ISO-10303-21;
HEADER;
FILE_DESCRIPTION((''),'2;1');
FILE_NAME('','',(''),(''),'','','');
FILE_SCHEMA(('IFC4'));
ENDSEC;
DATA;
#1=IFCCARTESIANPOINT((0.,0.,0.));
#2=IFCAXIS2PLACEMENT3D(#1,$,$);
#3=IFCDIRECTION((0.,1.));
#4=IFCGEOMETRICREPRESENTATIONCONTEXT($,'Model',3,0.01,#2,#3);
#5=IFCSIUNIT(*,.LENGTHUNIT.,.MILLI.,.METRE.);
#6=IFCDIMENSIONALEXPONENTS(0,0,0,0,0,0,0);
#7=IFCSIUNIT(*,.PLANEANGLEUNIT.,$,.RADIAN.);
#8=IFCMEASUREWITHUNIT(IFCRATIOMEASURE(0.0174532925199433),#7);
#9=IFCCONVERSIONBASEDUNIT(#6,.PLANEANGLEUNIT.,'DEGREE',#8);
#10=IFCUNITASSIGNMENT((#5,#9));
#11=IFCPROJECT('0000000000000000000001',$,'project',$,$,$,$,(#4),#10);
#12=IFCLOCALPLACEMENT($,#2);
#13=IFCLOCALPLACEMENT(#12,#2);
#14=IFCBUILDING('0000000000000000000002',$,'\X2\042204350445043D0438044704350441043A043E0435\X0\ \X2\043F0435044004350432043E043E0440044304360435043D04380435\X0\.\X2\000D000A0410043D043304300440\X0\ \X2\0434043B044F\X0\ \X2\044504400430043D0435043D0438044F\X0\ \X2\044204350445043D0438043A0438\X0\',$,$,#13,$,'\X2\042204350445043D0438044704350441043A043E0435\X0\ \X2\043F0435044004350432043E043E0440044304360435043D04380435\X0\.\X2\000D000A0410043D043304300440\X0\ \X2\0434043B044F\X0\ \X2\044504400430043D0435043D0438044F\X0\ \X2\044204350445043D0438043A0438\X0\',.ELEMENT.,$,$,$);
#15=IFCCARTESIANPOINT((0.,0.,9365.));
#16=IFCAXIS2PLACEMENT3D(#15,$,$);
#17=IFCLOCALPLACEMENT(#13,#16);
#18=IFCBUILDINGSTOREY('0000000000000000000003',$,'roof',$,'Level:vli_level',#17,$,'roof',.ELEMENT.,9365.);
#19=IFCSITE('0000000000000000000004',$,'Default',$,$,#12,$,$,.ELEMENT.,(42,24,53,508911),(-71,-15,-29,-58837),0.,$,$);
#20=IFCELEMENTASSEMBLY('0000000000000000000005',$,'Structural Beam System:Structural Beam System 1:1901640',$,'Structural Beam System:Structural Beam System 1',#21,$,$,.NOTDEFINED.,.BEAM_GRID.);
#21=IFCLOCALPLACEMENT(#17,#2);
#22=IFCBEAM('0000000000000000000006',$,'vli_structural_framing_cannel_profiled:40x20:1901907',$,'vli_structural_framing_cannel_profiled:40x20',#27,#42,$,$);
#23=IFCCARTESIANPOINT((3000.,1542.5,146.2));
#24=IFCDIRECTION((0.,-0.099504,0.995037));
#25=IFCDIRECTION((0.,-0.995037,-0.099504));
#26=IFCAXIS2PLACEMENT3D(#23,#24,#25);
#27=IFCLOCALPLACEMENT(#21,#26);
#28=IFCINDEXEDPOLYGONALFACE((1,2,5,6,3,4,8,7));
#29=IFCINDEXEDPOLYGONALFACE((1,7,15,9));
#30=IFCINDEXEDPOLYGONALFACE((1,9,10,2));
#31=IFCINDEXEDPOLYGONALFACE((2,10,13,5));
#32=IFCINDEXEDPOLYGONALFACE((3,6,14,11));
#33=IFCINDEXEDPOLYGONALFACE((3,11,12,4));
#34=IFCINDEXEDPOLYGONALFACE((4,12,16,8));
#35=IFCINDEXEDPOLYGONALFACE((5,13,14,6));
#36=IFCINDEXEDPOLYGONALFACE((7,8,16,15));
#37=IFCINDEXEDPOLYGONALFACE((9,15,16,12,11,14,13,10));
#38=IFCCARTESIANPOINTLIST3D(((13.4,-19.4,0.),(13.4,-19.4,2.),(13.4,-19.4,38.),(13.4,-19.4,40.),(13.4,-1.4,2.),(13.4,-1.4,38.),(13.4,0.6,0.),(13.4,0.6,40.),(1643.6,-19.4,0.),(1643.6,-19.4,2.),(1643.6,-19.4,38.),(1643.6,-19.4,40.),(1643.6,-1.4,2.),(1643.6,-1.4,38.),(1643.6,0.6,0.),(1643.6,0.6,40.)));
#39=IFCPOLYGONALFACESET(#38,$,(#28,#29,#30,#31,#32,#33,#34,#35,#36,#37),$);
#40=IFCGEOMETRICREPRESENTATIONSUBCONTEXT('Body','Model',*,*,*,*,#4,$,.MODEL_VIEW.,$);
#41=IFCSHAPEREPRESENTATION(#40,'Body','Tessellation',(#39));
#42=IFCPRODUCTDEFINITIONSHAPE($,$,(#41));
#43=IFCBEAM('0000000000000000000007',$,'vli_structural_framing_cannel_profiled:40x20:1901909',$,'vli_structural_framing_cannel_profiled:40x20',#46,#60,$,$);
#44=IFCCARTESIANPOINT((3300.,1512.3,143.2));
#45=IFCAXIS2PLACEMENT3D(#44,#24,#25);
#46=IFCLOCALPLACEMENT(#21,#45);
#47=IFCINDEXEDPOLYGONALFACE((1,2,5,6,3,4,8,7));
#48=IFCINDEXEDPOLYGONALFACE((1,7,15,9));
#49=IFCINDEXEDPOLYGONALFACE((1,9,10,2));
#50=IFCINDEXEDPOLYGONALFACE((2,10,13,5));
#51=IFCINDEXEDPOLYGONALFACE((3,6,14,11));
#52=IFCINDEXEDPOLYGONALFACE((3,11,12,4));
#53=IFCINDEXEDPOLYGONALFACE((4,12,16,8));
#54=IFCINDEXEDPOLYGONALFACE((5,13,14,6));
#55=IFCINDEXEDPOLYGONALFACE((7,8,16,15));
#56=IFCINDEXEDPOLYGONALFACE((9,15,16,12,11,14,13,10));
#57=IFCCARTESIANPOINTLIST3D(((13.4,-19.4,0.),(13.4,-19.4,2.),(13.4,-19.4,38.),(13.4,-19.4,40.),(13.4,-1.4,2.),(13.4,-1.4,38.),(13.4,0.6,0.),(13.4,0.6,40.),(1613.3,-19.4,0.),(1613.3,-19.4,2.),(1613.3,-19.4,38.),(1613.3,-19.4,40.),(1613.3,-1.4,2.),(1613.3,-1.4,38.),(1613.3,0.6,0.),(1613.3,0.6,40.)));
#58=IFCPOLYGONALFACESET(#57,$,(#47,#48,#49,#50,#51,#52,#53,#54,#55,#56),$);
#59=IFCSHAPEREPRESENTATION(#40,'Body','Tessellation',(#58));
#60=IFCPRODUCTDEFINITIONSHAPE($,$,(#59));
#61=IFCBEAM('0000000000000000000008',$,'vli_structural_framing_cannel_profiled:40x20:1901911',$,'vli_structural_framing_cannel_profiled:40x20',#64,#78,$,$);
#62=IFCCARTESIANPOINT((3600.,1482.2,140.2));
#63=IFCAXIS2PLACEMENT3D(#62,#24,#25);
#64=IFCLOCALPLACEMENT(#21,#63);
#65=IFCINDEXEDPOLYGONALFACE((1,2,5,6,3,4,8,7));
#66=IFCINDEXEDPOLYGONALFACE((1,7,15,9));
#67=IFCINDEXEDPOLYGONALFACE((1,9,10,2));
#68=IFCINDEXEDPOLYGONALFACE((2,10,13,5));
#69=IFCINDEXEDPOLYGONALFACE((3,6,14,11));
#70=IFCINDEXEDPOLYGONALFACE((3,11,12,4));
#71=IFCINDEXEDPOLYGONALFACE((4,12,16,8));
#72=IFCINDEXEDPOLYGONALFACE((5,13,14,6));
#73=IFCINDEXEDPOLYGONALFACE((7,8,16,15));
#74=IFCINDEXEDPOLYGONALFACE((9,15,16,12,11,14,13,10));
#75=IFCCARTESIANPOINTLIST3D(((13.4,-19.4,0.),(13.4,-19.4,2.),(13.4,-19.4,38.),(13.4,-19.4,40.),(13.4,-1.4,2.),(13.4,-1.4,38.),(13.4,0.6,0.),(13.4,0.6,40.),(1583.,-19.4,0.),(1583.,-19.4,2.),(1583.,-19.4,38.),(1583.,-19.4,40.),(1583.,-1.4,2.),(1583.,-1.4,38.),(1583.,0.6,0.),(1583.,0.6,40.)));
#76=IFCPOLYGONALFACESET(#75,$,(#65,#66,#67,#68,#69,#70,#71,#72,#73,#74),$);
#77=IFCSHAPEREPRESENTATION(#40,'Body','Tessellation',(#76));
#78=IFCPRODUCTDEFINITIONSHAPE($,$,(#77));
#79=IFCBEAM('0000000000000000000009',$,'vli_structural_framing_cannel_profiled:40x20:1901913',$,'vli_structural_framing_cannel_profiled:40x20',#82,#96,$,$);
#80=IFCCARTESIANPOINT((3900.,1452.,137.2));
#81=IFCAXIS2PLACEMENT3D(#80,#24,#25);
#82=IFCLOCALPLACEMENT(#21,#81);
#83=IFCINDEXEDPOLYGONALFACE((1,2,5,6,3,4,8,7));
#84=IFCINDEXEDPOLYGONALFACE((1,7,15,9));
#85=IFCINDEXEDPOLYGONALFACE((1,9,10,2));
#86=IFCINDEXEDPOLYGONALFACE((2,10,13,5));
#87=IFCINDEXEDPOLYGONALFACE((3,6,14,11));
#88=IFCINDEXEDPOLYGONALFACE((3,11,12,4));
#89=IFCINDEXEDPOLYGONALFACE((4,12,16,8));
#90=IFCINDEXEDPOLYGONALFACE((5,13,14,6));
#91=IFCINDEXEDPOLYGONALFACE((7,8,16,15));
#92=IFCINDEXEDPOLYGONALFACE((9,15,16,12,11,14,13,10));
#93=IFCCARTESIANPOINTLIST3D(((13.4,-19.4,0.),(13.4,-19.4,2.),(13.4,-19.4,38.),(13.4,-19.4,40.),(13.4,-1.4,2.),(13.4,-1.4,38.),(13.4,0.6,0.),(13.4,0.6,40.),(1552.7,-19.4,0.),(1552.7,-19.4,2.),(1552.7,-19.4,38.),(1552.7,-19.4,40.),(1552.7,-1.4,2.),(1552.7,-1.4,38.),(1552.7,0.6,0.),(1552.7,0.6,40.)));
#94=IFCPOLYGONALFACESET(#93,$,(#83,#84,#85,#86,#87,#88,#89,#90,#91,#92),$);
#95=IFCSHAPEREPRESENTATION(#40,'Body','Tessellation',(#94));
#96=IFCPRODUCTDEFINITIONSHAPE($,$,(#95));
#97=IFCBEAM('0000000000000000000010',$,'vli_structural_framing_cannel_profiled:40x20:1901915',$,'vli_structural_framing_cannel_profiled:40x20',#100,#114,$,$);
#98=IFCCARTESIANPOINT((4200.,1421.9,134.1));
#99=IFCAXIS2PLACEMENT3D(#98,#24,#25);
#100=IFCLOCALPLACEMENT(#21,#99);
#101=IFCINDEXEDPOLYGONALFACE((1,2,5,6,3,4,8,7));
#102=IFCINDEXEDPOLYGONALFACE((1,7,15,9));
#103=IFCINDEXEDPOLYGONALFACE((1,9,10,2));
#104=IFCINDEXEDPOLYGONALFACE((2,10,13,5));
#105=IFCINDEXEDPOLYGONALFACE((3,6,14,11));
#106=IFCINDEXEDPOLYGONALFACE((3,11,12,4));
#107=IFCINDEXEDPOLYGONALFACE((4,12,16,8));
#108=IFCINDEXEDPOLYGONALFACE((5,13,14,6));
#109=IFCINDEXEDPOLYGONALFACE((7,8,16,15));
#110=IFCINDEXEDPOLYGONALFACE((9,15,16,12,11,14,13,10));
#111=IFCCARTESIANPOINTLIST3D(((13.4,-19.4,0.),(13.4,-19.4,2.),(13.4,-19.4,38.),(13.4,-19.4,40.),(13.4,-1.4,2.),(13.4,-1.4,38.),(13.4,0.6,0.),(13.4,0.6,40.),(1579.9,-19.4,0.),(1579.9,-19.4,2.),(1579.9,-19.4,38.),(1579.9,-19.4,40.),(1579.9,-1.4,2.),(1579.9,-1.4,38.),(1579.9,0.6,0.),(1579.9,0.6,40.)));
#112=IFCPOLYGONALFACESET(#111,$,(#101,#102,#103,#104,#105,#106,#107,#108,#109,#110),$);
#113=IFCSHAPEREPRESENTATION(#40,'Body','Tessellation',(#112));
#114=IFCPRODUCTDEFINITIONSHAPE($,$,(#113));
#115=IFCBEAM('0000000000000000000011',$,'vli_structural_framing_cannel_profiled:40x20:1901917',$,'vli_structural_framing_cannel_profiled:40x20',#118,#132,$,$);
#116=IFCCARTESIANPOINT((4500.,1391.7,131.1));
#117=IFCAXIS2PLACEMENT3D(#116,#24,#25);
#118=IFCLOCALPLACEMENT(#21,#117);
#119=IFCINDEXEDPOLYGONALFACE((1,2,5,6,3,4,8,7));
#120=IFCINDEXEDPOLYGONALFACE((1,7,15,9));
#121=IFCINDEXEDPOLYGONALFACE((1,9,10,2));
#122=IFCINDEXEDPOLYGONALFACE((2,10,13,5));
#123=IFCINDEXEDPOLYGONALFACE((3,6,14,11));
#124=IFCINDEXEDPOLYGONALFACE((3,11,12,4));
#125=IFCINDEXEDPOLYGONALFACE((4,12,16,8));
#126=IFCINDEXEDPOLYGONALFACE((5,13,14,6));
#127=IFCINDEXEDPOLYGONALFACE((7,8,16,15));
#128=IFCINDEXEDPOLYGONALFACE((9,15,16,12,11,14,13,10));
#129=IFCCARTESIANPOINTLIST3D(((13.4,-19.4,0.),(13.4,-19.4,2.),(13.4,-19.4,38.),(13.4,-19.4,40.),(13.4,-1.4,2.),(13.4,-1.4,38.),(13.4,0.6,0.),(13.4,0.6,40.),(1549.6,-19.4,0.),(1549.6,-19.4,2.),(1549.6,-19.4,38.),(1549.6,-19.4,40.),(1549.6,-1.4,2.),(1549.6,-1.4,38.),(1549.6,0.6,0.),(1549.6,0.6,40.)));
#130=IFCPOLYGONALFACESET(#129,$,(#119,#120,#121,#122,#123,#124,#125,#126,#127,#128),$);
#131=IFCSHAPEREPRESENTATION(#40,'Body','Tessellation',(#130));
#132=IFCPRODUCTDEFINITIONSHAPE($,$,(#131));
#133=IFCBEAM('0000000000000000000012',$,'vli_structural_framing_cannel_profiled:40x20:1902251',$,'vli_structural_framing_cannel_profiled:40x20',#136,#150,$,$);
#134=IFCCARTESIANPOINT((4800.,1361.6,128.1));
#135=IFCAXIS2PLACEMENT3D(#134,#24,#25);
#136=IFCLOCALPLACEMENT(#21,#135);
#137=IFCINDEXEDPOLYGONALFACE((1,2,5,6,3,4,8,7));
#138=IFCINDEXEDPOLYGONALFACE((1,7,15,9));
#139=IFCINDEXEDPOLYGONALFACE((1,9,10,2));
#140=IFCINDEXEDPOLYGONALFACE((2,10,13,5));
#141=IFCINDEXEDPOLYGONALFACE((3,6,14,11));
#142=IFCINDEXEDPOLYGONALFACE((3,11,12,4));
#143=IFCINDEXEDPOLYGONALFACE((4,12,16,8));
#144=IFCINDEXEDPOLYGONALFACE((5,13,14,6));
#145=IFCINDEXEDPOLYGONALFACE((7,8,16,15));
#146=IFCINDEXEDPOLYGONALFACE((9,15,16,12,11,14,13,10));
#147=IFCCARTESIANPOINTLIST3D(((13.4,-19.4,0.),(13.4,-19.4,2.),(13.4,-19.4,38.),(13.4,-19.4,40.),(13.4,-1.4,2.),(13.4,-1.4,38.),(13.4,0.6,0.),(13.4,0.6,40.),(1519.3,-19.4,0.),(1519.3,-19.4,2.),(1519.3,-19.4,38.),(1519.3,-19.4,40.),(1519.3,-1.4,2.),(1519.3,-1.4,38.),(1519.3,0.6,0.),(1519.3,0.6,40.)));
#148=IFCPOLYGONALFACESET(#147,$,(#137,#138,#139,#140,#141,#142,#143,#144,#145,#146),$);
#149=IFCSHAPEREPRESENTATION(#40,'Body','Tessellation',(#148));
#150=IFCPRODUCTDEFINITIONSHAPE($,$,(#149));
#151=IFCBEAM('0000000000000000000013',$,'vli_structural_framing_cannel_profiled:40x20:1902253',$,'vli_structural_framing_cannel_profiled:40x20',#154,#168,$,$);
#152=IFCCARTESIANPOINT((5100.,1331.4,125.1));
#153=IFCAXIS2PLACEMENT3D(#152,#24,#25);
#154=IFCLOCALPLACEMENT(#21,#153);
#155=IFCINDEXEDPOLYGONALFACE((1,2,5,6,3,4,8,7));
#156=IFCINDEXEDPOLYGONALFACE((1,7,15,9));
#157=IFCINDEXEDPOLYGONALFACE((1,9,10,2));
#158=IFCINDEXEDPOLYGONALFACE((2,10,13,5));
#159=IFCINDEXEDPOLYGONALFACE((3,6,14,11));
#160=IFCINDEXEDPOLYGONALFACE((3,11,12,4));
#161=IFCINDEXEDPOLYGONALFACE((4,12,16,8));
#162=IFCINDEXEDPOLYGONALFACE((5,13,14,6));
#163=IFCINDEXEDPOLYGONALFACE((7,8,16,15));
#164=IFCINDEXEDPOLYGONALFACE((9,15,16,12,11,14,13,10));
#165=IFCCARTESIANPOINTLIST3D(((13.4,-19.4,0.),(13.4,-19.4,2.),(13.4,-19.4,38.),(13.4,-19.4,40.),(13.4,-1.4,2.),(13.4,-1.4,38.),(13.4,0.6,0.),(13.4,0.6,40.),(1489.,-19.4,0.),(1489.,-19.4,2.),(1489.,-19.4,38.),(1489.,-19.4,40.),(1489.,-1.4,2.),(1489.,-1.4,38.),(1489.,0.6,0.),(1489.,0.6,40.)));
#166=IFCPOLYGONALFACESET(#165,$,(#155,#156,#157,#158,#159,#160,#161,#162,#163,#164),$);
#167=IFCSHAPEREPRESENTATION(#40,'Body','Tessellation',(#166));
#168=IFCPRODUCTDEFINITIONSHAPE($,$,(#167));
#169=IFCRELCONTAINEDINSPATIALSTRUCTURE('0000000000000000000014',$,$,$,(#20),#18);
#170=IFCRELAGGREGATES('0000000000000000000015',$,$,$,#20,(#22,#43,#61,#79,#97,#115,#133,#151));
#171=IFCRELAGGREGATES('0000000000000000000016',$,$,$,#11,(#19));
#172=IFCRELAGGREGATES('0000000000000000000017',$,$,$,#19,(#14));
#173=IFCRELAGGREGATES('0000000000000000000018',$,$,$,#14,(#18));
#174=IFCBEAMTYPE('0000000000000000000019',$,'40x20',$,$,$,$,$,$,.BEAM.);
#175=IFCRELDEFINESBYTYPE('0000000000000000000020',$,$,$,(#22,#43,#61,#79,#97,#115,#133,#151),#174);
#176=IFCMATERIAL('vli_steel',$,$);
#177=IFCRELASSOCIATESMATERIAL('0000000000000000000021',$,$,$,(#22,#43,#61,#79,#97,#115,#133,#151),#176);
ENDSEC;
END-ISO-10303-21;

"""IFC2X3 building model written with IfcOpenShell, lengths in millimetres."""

from ifc_helpers import new_model, entity, si_unit, converted_unit, direction, frame, origin, place, context, subcontext, project, spatial, polyline, outline, extrude, material, type_object, element, aggregate, save


model = new_model("IFC2X3")

# Units and contexts
model_context = context("Model", 3, precision=0.01, world=origin(), true_north=direction((0.0, 1.0)))
body_context = subcontext(model_context, "Body", "Model", "MODEL_VIEW")
ifc_project = project(units=[si_unit("LENGTHUNIT", "METRE", prefix="MILLI"), converted_unit("PLANEANGLEUNIT", "DEGREE", entity("IfcRatioMeasure", 0.0174532925199433), si_unit("PLANEANGLEUNIT", "RADIAN"), dimensions=[0, 0, 0, 0, 0, 0, 0])], contexts=[model_context])

# Site, building, storey
site_placement = place(None, origin())
site = spatial("IfcSite", under=ifc_project, at=site_placement, Name="Default", CompositionType="ELEMENT", RefLatitude=(42, 24, 53, 508911), RefLongitude=(-71, -15, -29, -58837), RefElevation=0.0)
building_placement = place(site_placement, origin())
building = spatial("IfcBuilding", under=site, at=building_placement, Name="Техническое перевооружение.\r\nАнгар для хранения техники", LongName="Техническое перевооружение.\r\nАнгар для хранения техники", CompositionType="ELEMENT")
storey_placement = place(building_placement, frame((0.0, 0.0, 9365.0)))
storey = spatial("IfcBuildingStorey", under=building, at=storey_placement, Name="roof", ObjectType="Level:vli_level", LongName="roof", CompositionType="ELEMENT", Elevation=9365.0)

# Element assembly, beams
assembly_placement = place(storey_placement, origin())
assembly = element("IfcElementAssembly", 1, at=assembly_placement, inside=storey, Name="Structural Beam System:Structural Beam System 1:1901640", ObjectType="Structural Beam System:Structural Beam System 1", AssemblyPlace="NOTDEFINED", PredefinedType="BEAM_GRID")
ifc_material = material(Name="vli_steel")
beam_type = type_object("IfcBeamType", Name="40x20", PredefinedType="BEAM")
beam_1_placement = place(assembly_placement, frame((3000.0, 1542.5, 146.2), z_axis=(0.0, -0.099504, 0.995037), x_axis=(0.0, -0.995037, -0.099504)))
beam_1 = element("IfcBeam", 2, at=beam_1_placement, type_object=beam_type, material=ifc_material, Name="vli_structural_framing_cannel_profiled:40x20:1901907", ObjectType="vli_structural_framing_cannel_profiled:40x20", context=body_context, shape_type="SweptSolid", body=[
    extrude(outline(polyline([(-20.0, -9.5), (-18.0, -9.5), (-18.0, 8.5), (18.0, 8.5), (18.0, -9.5), (20.0, -9.5), (20.0, 10.5), (-20.0, 10.5), (-20.0, -9.5)])), frame((13.4, -9.9, 20.0), z_axis=(1.0, 0.0, 0.0), x_axis=(0.0, 0.0, -1.0)), (0.0, 0.0, 1.0), 1630.3),
])
beam_2_placement = place(assembly_placement, frame((3300.0, 1512.3, 143.2), z_axis=(0.0, -0.099504, 0.995037), x_axis=(0.0, -0.995037, -0.099504)))
beam_2 = element("IfcBeam", 3, at=beam_2_placement, type_object=beam_type, material=ifc_material, Name="vli_structural_framing_cannel_profiled:40x20:1901909", ObjectType="vli_structural_framing_cannel_profiled:40x20", context=body_context, shape_type="SweptSolid", body=[
    extrude(outline(polyline([(-20.0, -9.5), (-18.0, -9.5), (-18.0, 8.5), (18.0, 8.5), (18.0, -9.5), (20.0, -9.5), (20.0, 10.5), (-20.0, 10.5), (-20.0, -9.5)])), frame((13.4, -9.9, 20.0), z_axis=(1.0, 0.0, 0.0), x_axis=(0.0, 0.0, -1.0)), (0.0, 0.0, 1.0), 1600.0),
])
beam_3_placement = place(assembly_placement, frame((3600.0, 1482.2, 140.2), z_axis=(0.0, -0.099504, 0.995037), x_axis=(0.0, -0.995037, -0.099504)))
beam_3 = element("IfcBeam", 4, at=beam_3_placement, type_object=beam_type, material=ifc_material, Name="vli_structural_framing_cannel_profiled:40x20:1901911", ObjectType="vli_structural_framing_cannel_profiled:40x20", context=body_context, shape_type="SweptSolid", body=[
    extrude(outline(polyline([(-20.0, -9.5), (-18.0, -9.5), (-18.0, 8.5), (18.0, 8.5), (18.0, -9.5), (20.0, -9.5), (20.0, 10.5), (-20.0, 10.5), (-20.0, -9.5)])), frame((13.4, -9.9, 20.0), z_axis=(1.0, 0.0, 0.0), x_axis=(0.0, 0.0, -1.0)), (0.0, 0.0, 1.0), 1569.7),
])
beam_4_placement = place(assembly_placement, frame((3900.0, 1452.0, 137.2), z_axis=(0.0, -0.099504, 0.995037), x_axis=(0.0, -0.995037, -0.099504)))
beam_4 = element("IfcBeam", 5, at=beam_4_placement, type_object=beam_type, material=ifc_material, Name="vli_structural_framing_cannel_profiled:40x20:1901913", ObjectType="vli_structural_framing_cannel_profiled:40x20", context=body_context, shape_type="SweptSolid", body=[
    extrude(outline(polyline([(-20.0, -9.5), (-18.0, -9.5), (-18.0, 8.5), (18.0, 8.5), (18.0, -9.5), (20.0, -9.5), (20.0, 10.5), (-20.0, 10.5), (-20.0, -9.5)])), frame((13.4, -9.9, 20.0), z_axis=(1.0, 0.0, 0.0), x_axis=(0.0, 0.0, -1.0)), (0.0, 0.0, 1.0), 1539.4),
])
beam_5_placement = place(assembly_placement, frame((4200.0, 1421.9, 134.1), z_axis=(0.0, -0.099504, 0.995037), x_axis=(0.0, -0.995037, -0.099504)))
beam_5 = element("IfcBeam", 6, at=beam_5_placement, type_object=beam_type, material=ifc_material, Name="vli_structural_framing_cannel_profiled:40x20:1901915", ObjectType="vli_structural_framing_cannel_profiled:40x20", context=body_context, shape_type="SweptSolid", body=[
    extrude(outline(polyline([(-20.0, -9.5), (-18.0, -9.5), (-18.0, 8.5), (18.0, 8.5), (18.0, -9.5), (20.0, -9.5), (20.0, 10.5), (-20.0, 10.5), (-20.0, -9.5)])), frame((13.4, -9.9, 20.0), z_axis=(1.0, 0.0, 0.0), x_axis=(0.0, 0.0, -1.0)), (0.0, 0.0, 1.0), 1566.6),
])
beam_6_placement = place(assembly_placement, frame((4500.0, 1391.7, 131.1), z_axis=(0.0, -0.099504, 0.995037), x_axis=(0.0, -0.995037, -0.099504)))
beam_6 = element("IfcBeam", 7, at=beam_6_placement, type_object=beam_type, material=ifc_material, Name="vli_structural_framing_cannel_profiled:40x20:1901917", ObjectType="vli_structural_framing_cannel_profiled:40x20", context=body_context, shape_type="SweptSolid", body=[
    extrude(outline(polyline([(-20.0, -9.5), (-18.0, -9.5), (-18.0, 8.5), (18.0, 8.5), (18.0, -9.5), (20.0, -9.5), (20.0, 10.5), (-20.0, 10.5), (-20.0, -9.5)])), frame((13.4, -9.9, 20.0), z_axis=(1.0, 0.0, 0.0), x_axis=(0.0, 0.0, -1.0)), (0.0, 0.0, 1.0), 1536.3),
])
beam_7_placement = place(assembly_placement, frame((4800.0, 1361.6, 128.1), z_axis=(0.0, -0.099504, 0.995037), x_axis=(0.0, -0.995037, -0.099504)))
beam_7 = element("IfcBeam", 8, at=beam_7_placement, type_object=beam_type, material=ifc_material, Name="vli_structural_framing_cannel_profiled:40x20:1902251", ObjectType="vli_structural_framing_cannel_profiled:40x20", context=body_context, shape_type="SweptSolid", body=[
    extrude(outline(polyline([(-20.0, -9.5), (-18.0, -9.5), (-18.0, 8.5), (18.0, 8.5), (18.0, -9.5), (20.0, -9.5), (20.0, 10.5), (-20.0, 10.5), (-20.0, -9.5)])), frame((13.4, -9.9, 20.0), z_axis=(1.0, 0.0, 0.0), x_axis=(0.0, 0.0, -1.0)), (0.0, 0.0, 1.0), 1506.0),
])
beam_8_placement = place(assembly_placement, frame((5100.0, 1331.4, 125.1), z_axis=(0.0, -0.099504, 0.995037), x_axis=(0.0, -0.995037, -0.099504)))
beam_8 = element("IfcBeam", 9, at=beam_8_placement, type_object=beam_type, material=ifc_material, Name="vli_structural_framing_cannel_profiled:40x20:1902253", ObjectType="vli_structural_framing_cannel_profiled:40x20", context=body_context, shape_type="SweptSolid", body=[
    extrude(outline(polyline([(-20.0, -9.5), (-18.0, -9.5), (-18.0, 8.5), (18.0, 8.5), (18.0, -9.5), (20.0, -9.5), (20.0, 10.5), (-20.0, 10.5), (-20.0, -9.5)])), frame((13.4, -9.9, 20.0), z_axis=(1.0, 0.0, 0.0), x_axis=(0.0, 0.0, -1.0)), (0.0, 0.0, 1.0), 1475.7),
])
aggregate(assembly, [beam_1, beam_2, beam_3, beam_4, beam_5, beam_6, beam_7, beam_8])

save(model, "model.ifc")
